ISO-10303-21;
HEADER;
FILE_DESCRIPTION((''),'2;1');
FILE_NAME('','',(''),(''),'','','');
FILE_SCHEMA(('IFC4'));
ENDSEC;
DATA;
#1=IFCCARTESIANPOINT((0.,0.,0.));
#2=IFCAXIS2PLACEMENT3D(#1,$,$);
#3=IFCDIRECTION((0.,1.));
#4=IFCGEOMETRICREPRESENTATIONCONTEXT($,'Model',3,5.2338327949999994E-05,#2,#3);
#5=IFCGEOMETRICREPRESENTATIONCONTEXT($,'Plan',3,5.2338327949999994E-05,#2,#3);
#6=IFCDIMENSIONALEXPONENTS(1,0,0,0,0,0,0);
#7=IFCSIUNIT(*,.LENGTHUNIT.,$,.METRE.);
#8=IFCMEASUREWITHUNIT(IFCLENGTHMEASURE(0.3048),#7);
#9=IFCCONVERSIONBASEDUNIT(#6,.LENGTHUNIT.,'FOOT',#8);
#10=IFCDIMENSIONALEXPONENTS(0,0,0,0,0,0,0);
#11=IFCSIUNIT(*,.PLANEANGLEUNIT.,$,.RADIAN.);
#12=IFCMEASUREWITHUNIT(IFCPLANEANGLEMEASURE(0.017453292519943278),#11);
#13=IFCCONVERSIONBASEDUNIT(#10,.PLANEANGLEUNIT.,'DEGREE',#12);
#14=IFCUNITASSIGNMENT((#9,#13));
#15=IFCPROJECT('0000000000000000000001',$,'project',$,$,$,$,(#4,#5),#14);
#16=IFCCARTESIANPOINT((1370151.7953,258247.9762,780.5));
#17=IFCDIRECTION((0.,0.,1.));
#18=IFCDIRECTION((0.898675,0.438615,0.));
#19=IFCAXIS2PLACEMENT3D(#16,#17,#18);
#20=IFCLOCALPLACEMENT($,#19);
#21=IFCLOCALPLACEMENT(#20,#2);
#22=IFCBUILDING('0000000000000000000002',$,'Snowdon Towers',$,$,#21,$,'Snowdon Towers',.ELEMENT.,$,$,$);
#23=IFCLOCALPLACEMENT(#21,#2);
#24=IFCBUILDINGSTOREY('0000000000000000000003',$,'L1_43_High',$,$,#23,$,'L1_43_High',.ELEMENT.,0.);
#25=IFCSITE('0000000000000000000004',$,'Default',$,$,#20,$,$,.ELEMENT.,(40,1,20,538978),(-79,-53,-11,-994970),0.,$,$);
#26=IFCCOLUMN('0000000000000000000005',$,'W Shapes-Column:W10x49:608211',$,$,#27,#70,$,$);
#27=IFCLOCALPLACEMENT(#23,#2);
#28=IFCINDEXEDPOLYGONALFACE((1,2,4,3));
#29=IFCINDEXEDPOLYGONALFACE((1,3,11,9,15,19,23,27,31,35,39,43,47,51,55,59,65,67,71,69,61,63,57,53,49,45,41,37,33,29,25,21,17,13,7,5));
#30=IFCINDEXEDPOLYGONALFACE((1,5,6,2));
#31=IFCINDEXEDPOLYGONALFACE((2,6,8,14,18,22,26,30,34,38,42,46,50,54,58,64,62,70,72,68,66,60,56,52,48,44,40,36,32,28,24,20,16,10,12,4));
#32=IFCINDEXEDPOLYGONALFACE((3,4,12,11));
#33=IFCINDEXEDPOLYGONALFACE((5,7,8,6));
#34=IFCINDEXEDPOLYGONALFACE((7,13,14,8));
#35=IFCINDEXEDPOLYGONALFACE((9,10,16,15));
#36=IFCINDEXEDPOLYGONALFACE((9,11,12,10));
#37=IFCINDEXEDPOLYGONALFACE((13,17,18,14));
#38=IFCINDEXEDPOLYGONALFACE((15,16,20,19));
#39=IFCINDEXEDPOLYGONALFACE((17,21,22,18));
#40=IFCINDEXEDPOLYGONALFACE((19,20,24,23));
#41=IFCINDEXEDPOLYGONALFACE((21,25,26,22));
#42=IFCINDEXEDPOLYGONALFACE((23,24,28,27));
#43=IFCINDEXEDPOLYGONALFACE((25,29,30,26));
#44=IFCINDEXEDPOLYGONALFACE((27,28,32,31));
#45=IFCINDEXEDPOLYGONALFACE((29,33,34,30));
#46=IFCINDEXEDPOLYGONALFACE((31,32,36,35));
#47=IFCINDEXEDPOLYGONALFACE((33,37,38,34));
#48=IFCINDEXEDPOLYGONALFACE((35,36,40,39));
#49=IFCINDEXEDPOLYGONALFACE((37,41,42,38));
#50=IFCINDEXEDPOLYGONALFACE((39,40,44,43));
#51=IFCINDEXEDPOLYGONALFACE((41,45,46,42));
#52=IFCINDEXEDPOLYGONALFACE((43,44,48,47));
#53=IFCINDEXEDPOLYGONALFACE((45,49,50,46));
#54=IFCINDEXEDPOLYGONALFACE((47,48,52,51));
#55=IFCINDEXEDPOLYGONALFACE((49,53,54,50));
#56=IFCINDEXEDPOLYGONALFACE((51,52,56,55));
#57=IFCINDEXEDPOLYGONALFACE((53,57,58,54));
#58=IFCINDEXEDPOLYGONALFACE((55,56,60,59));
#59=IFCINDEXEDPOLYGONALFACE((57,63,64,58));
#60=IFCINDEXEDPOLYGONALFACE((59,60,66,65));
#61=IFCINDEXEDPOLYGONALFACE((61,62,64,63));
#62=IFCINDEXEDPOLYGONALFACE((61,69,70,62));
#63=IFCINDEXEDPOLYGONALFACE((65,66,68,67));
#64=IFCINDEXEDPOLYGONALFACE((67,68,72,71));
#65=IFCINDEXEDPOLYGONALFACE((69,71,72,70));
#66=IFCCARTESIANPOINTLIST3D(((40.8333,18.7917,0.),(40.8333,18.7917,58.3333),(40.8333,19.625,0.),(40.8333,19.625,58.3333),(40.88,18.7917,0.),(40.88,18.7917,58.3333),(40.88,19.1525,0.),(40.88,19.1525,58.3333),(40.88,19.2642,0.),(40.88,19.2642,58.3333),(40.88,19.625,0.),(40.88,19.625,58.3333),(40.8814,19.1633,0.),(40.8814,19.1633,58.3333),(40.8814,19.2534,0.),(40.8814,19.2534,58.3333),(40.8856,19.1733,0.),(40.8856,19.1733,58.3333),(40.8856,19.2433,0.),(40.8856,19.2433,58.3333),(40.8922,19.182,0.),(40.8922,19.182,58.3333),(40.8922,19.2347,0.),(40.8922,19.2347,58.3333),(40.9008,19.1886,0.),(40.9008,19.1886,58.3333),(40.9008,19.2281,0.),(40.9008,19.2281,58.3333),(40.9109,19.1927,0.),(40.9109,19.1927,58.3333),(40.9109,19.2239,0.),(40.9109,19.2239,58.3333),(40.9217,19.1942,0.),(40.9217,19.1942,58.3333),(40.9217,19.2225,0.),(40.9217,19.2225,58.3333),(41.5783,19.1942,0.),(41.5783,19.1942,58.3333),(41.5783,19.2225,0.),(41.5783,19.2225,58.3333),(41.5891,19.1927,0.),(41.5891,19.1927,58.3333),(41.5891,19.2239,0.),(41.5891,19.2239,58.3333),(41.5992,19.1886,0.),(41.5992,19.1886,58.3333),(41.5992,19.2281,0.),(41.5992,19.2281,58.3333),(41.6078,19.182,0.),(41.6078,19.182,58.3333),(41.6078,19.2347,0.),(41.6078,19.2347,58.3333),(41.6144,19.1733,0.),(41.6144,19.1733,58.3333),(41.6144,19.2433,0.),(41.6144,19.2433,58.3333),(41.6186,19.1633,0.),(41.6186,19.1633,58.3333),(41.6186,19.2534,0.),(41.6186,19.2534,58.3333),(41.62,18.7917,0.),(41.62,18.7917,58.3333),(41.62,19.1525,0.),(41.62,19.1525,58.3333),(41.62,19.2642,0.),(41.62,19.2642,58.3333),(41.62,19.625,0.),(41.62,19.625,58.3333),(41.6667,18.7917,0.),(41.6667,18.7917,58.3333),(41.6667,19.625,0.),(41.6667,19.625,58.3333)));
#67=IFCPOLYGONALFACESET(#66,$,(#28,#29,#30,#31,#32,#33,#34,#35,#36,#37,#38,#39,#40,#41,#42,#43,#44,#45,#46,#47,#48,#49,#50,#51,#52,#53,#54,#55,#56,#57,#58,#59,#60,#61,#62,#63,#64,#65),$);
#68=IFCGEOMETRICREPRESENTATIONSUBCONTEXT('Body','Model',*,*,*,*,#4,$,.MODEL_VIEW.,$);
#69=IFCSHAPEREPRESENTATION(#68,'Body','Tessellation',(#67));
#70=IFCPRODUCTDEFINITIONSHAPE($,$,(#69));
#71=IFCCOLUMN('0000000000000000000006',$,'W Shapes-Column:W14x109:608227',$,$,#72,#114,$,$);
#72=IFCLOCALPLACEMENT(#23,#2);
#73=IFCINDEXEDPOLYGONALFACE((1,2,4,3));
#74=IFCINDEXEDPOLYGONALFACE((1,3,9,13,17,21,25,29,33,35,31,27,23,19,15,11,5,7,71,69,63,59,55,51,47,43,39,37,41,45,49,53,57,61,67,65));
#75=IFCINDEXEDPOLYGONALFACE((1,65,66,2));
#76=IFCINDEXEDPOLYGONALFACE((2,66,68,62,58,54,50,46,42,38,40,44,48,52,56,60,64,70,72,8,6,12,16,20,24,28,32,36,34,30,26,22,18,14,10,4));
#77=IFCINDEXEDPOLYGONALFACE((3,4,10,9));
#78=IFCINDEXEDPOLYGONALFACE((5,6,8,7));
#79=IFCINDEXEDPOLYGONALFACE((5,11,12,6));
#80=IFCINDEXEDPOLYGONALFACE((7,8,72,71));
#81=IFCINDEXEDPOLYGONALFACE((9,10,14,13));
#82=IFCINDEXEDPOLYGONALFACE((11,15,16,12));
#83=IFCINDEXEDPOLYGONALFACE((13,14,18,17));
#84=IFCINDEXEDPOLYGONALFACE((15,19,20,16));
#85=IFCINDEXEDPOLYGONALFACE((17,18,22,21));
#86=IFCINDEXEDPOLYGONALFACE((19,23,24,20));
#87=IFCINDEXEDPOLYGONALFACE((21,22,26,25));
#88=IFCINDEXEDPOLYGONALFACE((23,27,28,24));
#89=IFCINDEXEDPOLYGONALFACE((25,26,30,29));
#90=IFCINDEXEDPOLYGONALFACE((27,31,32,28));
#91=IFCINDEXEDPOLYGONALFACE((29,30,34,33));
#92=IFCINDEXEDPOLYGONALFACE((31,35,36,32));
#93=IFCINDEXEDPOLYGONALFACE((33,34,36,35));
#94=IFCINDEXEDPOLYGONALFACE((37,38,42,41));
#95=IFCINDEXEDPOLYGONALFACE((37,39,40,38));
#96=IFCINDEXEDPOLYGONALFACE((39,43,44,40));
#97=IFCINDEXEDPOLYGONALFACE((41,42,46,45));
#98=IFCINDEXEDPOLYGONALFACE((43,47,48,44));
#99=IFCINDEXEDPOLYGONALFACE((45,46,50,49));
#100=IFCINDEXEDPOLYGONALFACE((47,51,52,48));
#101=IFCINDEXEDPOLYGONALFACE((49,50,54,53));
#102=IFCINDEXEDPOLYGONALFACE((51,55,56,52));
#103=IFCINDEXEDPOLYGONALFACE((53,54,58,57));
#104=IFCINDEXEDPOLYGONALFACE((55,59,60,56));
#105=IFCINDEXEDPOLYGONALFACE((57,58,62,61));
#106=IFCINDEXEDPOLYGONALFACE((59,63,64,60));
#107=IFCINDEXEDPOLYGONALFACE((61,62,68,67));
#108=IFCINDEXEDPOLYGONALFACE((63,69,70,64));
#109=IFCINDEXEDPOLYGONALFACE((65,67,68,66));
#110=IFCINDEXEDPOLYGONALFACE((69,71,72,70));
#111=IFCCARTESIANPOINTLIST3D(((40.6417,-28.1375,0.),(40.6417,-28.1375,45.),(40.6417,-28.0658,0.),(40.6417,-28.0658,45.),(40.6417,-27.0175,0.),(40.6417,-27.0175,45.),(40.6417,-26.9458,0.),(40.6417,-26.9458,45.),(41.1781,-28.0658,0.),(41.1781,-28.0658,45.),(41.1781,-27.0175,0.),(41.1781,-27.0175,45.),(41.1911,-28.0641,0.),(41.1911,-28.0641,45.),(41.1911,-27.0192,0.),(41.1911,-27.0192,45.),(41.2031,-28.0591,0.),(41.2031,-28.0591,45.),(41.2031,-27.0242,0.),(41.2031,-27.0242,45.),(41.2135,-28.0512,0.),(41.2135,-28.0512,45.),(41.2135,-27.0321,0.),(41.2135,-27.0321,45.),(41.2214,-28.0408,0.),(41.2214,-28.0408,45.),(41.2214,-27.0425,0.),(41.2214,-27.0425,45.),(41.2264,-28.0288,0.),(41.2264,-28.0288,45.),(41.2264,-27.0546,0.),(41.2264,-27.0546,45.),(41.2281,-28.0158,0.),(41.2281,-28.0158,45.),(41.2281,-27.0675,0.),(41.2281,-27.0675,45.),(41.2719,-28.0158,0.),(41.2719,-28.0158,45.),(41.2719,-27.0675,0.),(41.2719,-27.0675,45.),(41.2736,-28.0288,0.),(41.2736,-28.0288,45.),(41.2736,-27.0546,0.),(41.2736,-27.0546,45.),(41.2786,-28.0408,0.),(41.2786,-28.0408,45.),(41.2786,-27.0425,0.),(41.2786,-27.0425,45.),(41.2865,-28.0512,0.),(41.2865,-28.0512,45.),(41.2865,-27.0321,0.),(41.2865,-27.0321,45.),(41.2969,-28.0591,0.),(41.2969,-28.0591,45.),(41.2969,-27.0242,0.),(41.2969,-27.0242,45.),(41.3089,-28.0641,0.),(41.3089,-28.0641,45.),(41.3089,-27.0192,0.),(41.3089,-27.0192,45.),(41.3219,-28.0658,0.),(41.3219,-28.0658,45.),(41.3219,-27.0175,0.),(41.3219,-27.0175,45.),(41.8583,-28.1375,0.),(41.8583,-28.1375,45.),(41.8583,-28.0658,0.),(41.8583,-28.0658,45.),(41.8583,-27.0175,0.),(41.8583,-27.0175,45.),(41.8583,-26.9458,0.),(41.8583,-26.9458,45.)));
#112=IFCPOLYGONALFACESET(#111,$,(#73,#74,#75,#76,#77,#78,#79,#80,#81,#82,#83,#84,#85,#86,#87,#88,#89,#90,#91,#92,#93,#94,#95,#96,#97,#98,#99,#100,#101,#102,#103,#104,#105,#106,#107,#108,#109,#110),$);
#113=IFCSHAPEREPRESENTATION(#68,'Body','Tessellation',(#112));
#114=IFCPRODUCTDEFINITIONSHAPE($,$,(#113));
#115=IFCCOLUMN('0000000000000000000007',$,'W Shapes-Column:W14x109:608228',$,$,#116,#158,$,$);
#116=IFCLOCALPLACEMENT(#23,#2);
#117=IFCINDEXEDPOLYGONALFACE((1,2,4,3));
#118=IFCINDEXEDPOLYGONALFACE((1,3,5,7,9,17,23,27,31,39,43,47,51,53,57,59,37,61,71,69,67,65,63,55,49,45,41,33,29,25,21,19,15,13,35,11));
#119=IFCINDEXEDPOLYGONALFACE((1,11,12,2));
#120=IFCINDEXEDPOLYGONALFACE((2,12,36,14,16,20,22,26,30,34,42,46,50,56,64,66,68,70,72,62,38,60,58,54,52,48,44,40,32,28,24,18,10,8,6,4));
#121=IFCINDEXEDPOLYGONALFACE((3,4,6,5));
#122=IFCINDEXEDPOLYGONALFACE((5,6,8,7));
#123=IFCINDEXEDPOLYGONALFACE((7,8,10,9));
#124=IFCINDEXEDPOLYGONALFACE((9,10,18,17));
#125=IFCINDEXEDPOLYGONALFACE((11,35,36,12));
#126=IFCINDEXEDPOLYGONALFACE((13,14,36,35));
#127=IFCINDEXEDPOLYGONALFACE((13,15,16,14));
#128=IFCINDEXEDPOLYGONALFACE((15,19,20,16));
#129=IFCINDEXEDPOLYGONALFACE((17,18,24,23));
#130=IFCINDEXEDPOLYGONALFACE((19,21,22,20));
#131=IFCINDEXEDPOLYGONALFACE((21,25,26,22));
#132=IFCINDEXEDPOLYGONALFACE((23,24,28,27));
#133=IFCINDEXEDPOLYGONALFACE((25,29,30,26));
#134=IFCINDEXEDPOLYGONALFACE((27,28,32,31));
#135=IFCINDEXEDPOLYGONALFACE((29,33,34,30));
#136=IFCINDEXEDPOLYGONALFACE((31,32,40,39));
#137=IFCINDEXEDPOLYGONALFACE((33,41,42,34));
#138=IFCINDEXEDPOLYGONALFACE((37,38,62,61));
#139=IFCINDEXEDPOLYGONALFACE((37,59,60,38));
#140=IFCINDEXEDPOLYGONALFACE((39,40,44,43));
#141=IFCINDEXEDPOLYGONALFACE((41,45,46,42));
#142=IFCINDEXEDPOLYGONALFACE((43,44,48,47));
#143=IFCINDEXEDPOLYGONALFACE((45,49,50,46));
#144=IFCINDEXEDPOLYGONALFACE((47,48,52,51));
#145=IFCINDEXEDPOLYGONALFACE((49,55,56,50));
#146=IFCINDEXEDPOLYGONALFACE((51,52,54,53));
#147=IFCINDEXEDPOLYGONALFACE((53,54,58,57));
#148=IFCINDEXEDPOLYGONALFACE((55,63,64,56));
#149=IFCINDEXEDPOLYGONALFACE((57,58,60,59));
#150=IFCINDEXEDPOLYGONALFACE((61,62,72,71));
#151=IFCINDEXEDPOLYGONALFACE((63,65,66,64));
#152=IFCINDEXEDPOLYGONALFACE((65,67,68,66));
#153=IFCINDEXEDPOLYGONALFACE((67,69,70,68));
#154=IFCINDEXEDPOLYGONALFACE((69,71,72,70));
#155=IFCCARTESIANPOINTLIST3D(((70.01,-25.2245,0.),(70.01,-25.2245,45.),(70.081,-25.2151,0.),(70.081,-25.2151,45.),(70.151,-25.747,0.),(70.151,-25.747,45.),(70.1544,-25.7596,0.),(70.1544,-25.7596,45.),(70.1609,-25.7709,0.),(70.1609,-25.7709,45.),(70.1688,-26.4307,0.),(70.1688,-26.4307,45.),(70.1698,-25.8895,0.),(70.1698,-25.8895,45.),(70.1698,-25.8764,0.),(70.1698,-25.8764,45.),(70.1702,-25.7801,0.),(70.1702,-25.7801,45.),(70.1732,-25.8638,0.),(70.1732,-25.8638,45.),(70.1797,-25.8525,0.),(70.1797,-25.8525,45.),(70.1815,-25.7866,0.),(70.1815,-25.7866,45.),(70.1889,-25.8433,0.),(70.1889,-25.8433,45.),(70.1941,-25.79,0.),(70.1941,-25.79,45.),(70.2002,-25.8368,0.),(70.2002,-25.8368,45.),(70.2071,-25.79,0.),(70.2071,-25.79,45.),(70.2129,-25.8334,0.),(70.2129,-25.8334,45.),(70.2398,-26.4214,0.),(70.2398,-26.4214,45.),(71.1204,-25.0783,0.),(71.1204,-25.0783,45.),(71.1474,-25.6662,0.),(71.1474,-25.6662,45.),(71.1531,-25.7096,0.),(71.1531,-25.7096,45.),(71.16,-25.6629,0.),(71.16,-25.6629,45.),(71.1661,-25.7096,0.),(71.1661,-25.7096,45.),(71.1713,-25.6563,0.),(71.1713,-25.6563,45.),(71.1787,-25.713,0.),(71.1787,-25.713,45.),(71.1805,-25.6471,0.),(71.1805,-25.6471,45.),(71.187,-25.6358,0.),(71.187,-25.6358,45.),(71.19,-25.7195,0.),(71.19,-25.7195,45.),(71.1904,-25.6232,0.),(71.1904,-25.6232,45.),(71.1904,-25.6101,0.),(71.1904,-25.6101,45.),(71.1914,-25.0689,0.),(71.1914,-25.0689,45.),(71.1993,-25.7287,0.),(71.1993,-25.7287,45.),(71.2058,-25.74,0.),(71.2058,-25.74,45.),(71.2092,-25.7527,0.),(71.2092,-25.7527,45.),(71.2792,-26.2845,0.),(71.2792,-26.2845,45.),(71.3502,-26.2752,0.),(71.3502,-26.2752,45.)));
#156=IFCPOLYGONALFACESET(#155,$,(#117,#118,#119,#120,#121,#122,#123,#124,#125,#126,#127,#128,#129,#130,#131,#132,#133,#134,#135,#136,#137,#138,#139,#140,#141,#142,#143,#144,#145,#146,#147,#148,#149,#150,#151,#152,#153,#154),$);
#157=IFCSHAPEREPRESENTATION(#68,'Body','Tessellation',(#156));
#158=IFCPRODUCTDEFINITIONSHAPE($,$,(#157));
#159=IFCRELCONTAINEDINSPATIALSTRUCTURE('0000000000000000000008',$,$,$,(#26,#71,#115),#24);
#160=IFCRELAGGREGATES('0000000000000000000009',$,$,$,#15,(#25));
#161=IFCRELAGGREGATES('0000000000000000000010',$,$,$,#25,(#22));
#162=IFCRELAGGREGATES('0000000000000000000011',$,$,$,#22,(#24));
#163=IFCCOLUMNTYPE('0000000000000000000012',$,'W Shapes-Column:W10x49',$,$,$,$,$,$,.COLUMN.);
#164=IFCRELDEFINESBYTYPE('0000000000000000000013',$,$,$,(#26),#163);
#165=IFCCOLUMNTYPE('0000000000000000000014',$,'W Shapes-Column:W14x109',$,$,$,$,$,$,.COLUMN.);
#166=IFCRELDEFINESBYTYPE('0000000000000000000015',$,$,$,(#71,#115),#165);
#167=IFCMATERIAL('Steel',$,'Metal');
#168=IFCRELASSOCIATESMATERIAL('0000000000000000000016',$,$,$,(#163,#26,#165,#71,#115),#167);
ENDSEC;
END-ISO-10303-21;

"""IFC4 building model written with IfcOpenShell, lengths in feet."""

from ifc_helpers import new_model, entity, si_unit, converted_unit, direction, frame, origin, place, context, subcontext, project, spatial, line, arc, indexed_curve, outline, extrude, source, transform, mapped, material, type_object, type_shapes, element, save


model = new_model("IFC4")

# Units and contexts
model_context = context("Model", 3, precision=5.2338327949999994e-05, world=origin(), true_north=direction((0.0, 1.0)))
plan_context = context("Plan", 3, precision=5.2338327949999994e-05, world=origin(), true_north=direction((0.0, 1.0)))
body_context = subcontext(model_context, "Body", "Model", "MODEL_VIEW")
ifc_project = project(units=[converted_unit("LENGTHUNIT", "FOOT", entity("IfcLengthMeasure", 0.3048), si_unit("LENGTHUNIT", "METRE"), dimensions=[1, 0, 0, 0, 0, 0, 0]), converted_unit("PLANEANGLEUNIT", "DEGREE", entity("IfcPlaneAngleMeasure", 0.017453292519943278), si_unit("PLANEANGLEUNIT", "RADIAN"), dimensions=[0, 0, 0, 0, 0, 0, 0])], contexts=[model_context, plan_context])

# Site, building, storey
site_placement = place(None, frame((1370151.7953, 258247.9762, 780.5), z_axis=(0.0, 0.0, 1.0), x_axis=(0.898675, 0.438615, 0.0)))
site = spatial("IfcSite", under=ifc_project, at=site_placement, Name="Default", CompositionType="ELEMENT", RefLatitude=(40, 1, 20, 538978), RefLongitude=(-79, -53, -11, -994970), RefElevation=0.0)
building_placement = place(site_placement, origin())
building = spatial("IfcBuilding", under=site, at=building_placement, Name="Snowdon Towers", LongName="Snowdon Towers", CompositionType="ELEMENT")
storey_placement = place(building_placement, origin())
storey = spatial("IfcBuildingStorey", under=building, at=storey_placement, Name="L1_43_High", LongName="L1_43_High", CompositionType="ELEMENT", Elevation=0.0)

# Columns
ifc_material_1 = material(Name="Steel", Category="Metal")
column_type_1 = type_object("IfcColumnType", Name="W Shapes-Column:W10x49", PredefinedType="COLUMN", material=ifc_material_1)
shared_shape_1 = source(origin(), body_context, "Body", "SweptSolid", [
    extrude(outline(indexed_curve([(-0.4167, -0.4167), (0.4167, -0.4167), (0.4167, -0.37), (0.0558, -0.37), (0.0264, -0.3578), (0.0142, -0.3283), (0.0142, 0.3283), (0.0264, 0.3578), (0.0558, 0.37), (0.4167, 0.37), (0.4167, 0.4167), (-0.4167, 0.4167), (-0.4167, 0.37), (-0.0558, 0.37), (-0.0264, 0.3578), (-0.0142, 0.3283), (-0.0142, -0.3283), (-0.0264, -0.3578), (-0.0558, -0.37), (-0.4167, -0.37)], segments=[line(1, 2, 3, 4), arc(4, 5, 6), line(6, 7), arc(7, 8, 9), line(9, 10, 11, 12, 13, 14), arc(14, 15, 16), line(16, 17), arc(17, 18, 19), line(19, 20, 1)], self_intersect=False)), frame((0.0, 0.0, 0.0), z_axis=(0.0, 0.0, 1.0), x_axis=(-1.0, 0.0, 0.0)), (0.0, 0.0, 1.0), 58.3333),
])
type_shapes(column_type_1, [shared_shape_1])
column_1_placement = place(storey_placement, frame((41.25, 19.2083, 0.0), z_axis=(0.0, 0.0, 1.0), x_axis=(0.0, 1.0, 0.0)))
element("IfcColumn", 1, at=column_1_placement, inside=storey, type_object=column_type_1, material=ifc_material_1, Name="W Shapes-Column:W10x49:608211", context=body_context, shape_type="MappedRepresentation", body=[
    mapped(shared_shape_1, transform((0.0, 0.0, 0.0), scale=1.0)),
])
column_type_2 = type_object("IfcColumnType", Name="W Shapes-Column:W14x109", PredefinedType="COLUMN", material=ifc_material_1)
shared_shape_2 = source(origin(), body_context, "Body", "SweptSolid", [
    extrude(outline(indexed_curve([(-0.6083, -0.5958), (0.6083, -0.5958), (0.6083, -0.5242), (0.0719, -0.5242), (0.0365, -0.5095), (0.0219, -0.4742), (0.0219, 0.4742), (0.0365, 0.5095), (0.0719, 0.5242), (0.6083, 0.5242), (0.6083, 0.5958), (-0.6083, 0.5958), (-0.6083, 0.5242), (-0.0719, 0.5242), (-0.0365, 0.5095), (-0.0219, 0.4742), (-0.0219, -0.4742), (-0.0365, -0.5095), (-0.0719, -0.5242), (-0.6083, -0.5242)], segments=[line(1, 2, 3, 4), arc(4, 5, 6), line(6, 7), arc(7, 8, 9), line(9, 10, 11, 12, 13, 14), arc(14, 15, 16), line(16, 17), arc(17, 18, 19), line(19, 20, 1)], self_intersect=False)), frame((0.0, 0.0, 0.0), z_axis=(0.0, 0.0, 1.0), x_axis=(-1.0, 0.0, 0.0)), (0.0, 0.0, 1.0), 45.0),
])
type_shapes(column_type_2, [shared_shape_2])
for number, where, z_axis, x_axis, name in (
    (2, (41.25, -27.5417, 0.0), (0.0, 0.0, 1.0), (-1.0, 0.0, 0.0), "W Shapes-Column:W14x109:608227"),
    (3, (70.6801, -25.7498, 0.0), (0.0, 0.0, 1.0), (-0.130526, 0.991445, 0.0), "W Shapes-Column:W14x109:608228"),
):
    element("IfcColumn", number, at=place(storey_placement, frame(where, z_axis=z_axis, x_axis=x_axis)), inside=storey, type_object=column_type_2, material=ifc_material_1, Name=name, context=body_context, shape_type="MappedRepresentation", body=[
        mapped(shared_shape_2, transform((0.0, 0.0, 0.0), scale=1.0)),
    ])

save(model, "model.ifc")
